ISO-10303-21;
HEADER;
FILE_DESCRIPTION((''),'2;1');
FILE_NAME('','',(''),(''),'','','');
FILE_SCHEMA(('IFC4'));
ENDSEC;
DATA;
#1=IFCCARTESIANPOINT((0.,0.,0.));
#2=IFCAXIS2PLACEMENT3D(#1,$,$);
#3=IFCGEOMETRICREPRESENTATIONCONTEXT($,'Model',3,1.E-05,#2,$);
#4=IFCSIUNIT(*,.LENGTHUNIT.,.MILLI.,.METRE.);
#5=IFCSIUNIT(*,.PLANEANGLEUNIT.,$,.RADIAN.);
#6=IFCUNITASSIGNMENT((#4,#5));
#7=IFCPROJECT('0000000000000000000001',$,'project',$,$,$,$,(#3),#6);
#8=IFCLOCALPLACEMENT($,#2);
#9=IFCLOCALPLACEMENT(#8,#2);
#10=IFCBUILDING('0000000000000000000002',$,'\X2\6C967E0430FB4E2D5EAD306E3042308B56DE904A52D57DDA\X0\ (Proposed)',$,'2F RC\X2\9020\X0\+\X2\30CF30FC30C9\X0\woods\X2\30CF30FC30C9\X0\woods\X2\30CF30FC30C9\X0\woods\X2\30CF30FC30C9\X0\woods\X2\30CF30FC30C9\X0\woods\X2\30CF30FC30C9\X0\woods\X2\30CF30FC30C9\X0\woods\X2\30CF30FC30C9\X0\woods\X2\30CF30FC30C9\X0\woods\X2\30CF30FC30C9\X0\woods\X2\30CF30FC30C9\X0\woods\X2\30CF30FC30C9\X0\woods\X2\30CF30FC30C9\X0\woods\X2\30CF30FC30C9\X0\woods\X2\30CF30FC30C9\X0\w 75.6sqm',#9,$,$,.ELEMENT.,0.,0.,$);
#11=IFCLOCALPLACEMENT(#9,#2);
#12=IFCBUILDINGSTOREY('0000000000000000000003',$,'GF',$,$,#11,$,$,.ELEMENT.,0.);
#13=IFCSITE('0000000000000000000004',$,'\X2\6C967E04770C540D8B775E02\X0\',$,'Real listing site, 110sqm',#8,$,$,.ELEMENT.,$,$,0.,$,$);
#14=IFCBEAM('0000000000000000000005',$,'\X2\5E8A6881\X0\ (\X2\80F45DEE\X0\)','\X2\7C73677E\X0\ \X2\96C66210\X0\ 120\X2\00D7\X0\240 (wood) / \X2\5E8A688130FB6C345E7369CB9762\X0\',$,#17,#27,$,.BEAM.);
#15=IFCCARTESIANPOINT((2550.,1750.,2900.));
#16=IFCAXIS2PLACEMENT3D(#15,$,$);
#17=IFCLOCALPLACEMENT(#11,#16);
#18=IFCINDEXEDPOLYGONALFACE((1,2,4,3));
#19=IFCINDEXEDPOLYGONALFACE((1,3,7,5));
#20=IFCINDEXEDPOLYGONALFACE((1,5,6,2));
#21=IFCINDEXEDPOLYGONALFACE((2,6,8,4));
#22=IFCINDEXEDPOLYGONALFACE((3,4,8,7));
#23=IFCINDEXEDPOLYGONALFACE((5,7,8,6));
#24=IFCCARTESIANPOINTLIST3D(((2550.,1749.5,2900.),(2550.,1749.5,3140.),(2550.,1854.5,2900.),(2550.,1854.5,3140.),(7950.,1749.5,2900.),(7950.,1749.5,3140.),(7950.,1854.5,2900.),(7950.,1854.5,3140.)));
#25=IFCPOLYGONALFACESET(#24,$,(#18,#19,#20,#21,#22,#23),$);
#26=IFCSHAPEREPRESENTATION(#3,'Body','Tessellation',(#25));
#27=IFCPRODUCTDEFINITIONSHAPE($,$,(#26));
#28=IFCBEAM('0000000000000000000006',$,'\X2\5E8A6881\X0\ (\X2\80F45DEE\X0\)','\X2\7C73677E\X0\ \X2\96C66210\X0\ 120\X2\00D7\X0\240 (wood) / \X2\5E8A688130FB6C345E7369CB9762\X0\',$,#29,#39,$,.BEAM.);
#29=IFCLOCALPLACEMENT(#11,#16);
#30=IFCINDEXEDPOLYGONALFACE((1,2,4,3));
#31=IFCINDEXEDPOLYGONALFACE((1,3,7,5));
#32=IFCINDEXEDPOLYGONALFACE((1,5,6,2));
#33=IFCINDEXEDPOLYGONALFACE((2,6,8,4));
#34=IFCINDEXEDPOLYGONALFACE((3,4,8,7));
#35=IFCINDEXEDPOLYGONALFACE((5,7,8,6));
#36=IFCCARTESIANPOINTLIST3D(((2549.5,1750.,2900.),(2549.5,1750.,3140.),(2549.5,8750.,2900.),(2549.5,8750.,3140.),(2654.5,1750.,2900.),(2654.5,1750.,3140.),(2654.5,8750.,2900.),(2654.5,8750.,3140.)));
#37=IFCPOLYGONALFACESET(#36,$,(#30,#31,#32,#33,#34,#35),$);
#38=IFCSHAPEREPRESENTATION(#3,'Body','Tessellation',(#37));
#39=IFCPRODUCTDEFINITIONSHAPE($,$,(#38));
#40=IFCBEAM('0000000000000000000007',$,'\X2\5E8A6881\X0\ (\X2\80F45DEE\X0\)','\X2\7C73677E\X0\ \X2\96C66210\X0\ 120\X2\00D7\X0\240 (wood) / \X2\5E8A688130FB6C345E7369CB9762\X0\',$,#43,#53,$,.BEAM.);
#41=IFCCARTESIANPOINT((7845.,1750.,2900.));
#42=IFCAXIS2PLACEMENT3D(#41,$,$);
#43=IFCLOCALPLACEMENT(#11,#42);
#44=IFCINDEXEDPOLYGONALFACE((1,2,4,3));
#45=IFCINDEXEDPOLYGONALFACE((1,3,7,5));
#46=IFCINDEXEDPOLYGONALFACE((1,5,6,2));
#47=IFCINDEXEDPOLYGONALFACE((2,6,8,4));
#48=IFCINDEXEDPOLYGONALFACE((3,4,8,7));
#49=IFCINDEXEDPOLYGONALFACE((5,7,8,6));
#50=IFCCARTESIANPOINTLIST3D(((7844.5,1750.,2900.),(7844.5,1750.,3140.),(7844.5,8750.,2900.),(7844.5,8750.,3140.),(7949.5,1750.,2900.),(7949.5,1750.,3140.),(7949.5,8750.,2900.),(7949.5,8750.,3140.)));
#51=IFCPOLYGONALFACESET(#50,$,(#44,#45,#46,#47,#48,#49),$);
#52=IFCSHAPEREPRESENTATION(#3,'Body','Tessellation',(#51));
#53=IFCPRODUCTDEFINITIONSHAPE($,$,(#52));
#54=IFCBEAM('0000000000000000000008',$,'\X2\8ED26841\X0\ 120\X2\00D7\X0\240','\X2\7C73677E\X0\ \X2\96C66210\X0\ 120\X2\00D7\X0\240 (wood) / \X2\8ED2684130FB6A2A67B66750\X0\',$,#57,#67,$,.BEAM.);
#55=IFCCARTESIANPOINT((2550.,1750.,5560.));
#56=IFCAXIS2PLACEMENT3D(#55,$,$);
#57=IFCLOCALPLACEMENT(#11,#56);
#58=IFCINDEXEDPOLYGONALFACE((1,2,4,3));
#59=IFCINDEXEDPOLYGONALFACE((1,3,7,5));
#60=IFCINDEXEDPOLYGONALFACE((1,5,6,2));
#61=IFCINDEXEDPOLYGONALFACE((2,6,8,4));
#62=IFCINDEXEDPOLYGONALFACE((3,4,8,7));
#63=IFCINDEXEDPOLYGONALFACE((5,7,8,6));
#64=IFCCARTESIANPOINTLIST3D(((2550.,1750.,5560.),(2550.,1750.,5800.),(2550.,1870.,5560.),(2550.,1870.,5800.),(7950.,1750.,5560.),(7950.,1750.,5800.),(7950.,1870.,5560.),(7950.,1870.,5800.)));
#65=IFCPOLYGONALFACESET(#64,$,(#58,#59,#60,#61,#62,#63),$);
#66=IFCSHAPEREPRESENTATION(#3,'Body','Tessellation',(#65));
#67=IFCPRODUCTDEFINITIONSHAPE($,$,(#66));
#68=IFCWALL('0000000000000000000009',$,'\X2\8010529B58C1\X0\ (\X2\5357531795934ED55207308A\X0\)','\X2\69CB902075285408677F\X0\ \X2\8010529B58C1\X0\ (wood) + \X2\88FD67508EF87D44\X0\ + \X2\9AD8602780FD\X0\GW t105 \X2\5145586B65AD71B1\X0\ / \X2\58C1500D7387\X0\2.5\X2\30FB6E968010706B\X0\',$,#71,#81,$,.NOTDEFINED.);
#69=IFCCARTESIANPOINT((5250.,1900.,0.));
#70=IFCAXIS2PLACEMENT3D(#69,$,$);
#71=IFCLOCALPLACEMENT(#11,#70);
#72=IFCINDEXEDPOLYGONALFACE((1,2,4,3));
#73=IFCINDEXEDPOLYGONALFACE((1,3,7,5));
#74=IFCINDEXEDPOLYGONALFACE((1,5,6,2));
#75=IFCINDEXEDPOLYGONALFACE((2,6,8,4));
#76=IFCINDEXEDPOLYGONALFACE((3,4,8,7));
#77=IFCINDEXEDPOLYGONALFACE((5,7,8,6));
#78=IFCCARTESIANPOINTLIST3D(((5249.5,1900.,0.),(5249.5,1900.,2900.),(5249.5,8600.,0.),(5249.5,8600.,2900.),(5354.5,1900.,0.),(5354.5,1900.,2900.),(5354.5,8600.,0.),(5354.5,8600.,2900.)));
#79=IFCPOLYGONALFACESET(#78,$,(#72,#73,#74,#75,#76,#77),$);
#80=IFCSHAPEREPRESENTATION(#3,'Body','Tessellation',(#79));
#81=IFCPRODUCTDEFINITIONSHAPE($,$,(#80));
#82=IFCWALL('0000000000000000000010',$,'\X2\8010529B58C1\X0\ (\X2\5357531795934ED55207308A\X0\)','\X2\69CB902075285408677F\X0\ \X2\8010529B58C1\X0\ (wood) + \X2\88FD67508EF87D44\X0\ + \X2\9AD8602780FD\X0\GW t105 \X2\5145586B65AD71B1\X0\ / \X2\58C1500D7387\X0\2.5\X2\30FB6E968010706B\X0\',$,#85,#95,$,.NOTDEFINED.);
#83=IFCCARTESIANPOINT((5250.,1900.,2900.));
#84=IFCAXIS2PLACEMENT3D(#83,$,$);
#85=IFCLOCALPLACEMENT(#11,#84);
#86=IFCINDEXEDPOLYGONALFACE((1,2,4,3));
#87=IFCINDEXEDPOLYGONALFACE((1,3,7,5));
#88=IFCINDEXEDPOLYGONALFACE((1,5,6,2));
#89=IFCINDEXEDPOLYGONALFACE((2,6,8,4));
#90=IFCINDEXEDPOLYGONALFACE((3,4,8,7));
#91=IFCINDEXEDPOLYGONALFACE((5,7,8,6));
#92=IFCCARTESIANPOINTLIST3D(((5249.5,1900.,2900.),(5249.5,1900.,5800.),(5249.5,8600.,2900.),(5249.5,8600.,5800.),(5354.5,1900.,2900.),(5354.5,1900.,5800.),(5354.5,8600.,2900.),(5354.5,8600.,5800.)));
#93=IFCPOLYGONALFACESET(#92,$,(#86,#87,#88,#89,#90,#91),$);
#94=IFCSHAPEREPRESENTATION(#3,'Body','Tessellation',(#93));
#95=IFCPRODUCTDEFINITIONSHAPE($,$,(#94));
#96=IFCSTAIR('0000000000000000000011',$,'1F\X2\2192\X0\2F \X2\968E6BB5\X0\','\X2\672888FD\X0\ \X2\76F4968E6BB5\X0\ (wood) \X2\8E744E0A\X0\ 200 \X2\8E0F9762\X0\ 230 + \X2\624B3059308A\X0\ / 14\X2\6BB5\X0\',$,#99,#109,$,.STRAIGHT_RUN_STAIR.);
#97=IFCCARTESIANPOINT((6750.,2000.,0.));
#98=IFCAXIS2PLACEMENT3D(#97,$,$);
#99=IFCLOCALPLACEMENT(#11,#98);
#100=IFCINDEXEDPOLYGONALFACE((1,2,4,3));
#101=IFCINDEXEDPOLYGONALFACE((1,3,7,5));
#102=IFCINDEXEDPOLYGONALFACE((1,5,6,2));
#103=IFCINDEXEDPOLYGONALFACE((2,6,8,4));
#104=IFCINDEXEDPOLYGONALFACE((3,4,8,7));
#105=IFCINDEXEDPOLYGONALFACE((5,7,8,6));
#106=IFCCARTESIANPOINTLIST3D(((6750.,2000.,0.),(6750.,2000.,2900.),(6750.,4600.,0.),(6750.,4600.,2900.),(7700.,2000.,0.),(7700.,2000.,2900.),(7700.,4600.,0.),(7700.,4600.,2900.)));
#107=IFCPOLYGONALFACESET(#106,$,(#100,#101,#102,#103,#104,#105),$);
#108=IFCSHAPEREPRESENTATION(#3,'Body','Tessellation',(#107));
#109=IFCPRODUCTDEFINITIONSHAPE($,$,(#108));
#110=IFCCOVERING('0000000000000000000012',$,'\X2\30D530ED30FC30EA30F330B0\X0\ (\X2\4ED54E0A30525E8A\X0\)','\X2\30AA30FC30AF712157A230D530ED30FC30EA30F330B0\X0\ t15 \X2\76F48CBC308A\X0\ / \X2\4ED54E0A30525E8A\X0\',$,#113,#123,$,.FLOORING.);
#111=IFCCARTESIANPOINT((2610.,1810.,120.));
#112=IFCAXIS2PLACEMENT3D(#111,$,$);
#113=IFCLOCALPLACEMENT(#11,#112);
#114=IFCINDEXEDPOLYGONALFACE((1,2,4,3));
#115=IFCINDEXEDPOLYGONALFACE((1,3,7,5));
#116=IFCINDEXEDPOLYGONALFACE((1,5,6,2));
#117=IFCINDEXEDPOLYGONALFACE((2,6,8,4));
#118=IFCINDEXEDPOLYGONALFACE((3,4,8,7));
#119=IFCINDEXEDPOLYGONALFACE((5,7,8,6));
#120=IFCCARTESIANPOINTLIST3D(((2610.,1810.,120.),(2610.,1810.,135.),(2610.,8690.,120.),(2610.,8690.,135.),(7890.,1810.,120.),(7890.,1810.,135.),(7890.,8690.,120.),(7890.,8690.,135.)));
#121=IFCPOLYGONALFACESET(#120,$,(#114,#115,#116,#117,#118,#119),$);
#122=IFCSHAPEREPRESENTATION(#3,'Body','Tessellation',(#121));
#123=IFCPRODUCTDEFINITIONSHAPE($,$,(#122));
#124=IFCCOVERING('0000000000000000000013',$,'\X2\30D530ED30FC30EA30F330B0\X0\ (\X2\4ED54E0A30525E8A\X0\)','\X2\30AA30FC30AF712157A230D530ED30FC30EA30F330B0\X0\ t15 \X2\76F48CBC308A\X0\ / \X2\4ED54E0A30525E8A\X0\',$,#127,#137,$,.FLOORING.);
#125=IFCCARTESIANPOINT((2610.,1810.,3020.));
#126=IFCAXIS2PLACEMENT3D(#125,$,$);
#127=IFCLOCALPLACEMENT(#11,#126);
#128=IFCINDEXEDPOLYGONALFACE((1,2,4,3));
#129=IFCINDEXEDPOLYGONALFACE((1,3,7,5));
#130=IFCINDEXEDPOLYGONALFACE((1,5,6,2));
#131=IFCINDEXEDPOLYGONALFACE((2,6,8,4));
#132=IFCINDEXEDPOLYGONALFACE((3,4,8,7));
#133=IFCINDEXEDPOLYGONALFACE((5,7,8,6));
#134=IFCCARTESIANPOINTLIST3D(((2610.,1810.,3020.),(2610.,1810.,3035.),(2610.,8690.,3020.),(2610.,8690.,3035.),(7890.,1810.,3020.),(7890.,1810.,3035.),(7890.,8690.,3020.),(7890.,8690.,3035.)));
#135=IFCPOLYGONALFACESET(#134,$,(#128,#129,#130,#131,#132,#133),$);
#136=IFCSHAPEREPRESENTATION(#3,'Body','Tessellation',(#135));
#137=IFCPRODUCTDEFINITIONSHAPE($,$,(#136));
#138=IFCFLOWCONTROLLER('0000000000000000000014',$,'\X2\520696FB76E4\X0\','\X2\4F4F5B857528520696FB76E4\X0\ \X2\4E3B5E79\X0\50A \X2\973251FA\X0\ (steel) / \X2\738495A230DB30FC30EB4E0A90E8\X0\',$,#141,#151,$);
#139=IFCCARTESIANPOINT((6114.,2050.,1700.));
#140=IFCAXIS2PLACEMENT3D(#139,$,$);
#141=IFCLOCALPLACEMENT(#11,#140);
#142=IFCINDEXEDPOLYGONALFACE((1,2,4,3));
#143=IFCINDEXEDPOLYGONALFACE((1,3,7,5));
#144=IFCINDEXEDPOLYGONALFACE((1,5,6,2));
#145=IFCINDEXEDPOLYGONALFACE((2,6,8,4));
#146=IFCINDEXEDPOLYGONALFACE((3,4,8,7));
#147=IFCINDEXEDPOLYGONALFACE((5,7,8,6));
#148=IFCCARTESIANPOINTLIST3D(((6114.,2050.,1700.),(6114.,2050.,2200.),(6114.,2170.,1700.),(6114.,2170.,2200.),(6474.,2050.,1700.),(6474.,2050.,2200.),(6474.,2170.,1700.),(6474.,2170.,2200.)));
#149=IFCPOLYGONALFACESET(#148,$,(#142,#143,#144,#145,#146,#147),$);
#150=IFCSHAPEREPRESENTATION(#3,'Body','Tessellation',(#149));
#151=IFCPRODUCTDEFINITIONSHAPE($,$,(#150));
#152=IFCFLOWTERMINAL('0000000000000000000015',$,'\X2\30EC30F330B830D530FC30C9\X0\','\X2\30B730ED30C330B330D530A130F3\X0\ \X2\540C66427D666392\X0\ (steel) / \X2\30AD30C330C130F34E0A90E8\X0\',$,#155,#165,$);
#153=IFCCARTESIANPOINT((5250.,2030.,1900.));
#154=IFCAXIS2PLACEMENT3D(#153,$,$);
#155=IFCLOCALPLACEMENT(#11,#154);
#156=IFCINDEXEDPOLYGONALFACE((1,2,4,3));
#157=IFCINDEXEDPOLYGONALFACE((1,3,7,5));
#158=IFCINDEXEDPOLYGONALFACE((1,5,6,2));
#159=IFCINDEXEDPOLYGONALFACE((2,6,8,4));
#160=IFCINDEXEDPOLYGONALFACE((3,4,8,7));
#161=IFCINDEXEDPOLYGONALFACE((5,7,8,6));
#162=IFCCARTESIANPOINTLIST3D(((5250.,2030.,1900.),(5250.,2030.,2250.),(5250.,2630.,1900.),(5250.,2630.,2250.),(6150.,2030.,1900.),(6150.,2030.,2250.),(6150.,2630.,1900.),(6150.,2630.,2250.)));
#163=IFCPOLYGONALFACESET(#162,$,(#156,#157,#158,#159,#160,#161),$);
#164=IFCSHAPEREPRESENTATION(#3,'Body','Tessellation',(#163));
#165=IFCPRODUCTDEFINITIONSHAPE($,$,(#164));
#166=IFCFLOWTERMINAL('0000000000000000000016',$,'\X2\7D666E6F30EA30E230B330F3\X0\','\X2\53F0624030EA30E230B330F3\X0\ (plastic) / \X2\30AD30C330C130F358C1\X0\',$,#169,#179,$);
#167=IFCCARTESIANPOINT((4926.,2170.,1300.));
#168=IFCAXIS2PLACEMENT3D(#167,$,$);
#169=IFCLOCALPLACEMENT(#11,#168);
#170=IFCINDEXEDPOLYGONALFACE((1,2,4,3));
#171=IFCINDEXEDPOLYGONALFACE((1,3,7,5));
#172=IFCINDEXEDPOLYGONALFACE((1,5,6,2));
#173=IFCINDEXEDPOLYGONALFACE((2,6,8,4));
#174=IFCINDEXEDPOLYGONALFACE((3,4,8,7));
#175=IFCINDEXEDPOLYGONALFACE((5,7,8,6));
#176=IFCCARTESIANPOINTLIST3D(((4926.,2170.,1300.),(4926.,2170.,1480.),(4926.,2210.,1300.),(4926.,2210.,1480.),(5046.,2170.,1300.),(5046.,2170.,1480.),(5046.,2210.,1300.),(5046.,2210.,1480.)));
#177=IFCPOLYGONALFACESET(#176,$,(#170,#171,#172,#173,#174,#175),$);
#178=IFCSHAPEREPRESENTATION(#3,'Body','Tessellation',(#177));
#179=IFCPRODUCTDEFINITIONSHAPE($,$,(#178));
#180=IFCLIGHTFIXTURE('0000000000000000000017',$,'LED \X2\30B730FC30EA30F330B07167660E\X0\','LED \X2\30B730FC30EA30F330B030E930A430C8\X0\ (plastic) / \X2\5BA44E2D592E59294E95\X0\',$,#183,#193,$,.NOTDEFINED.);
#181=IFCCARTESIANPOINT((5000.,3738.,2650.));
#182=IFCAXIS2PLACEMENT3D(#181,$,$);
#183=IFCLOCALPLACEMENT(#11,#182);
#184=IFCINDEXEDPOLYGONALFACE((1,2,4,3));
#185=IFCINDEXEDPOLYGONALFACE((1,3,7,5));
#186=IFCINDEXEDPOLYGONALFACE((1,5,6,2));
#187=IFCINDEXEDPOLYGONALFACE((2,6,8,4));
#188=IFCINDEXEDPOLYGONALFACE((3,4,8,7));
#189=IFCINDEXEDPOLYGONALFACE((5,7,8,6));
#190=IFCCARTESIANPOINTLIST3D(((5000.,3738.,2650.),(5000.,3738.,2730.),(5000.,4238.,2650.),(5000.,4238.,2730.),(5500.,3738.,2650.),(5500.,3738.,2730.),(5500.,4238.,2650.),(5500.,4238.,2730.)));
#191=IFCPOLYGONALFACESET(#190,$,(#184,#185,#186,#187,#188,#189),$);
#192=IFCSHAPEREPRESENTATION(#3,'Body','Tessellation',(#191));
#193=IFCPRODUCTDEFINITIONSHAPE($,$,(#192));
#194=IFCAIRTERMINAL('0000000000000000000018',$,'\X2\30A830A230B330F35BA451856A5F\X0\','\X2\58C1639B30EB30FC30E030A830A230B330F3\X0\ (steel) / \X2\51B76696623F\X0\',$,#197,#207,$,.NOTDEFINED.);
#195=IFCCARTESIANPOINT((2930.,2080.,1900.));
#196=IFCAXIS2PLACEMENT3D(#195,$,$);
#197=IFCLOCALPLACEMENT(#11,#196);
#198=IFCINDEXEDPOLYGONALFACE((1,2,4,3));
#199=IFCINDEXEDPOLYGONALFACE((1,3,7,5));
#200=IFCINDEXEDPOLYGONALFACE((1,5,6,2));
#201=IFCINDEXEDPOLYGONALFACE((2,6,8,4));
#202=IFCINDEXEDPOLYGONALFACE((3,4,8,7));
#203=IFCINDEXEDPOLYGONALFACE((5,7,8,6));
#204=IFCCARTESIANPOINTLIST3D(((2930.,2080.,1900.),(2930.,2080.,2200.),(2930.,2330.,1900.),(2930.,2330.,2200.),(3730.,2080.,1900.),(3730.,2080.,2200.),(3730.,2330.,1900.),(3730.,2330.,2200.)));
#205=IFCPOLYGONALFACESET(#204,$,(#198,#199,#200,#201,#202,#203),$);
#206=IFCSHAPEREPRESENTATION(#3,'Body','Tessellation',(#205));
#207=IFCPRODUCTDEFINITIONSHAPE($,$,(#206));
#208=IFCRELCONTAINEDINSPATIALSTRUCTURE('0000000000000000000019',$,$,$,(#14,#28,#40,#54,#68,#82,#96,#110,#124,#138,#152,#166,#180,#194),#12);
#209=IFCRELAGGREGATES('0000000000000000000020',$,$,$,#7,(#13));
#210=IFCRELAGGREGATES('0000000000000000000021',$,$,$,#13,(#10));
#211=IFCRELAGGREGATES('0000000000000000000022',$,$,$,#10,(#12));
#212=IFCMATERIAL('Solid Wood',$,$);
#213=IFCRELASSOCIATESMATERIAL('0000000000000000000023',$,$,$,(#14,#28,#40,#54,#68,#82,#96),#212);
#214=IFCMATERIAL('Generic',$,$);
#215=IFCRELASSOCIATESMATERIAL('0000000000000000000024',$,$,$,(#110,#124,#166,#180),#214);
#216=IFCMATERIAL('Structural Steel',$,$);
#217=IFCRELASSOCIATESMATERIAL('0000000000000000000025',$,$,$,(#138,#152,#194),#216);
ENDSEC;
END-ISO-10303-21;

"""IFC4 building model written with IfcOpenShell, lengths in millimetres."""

from ifc_helpers import new_model, si_unit, frame, frame_2d, origin, place, context, project, spatial, rectangle, extrude, material, element, save


model = new_model("IFC4")

# Units and contexts
model_context = context("Model", 3, precision=1e-05, world=origin())
ifc_project = project(units=[si_unit("LENGTHUNIT", "METRE", prefix="MILLI"), si_unit("PLANEANGLEUNIT", "RADIAN")], contexts=[model_context])

# Site, building, storey
site_placement = place(None, origin())
site = spatial("IfcSite", under=ifc_project, at=site_placement, Name="沖縄県名護市", ObjectType="Real listing site, 110sqm", CompositionType="ELEMENT", RefElevation=0.0)
building_placement = place(site_placement, origin())
building = spatial("IfcBuilding", under=site, at=building_placement, Name="沖縄・中庭のある回遊動線 (Proposed)", ObjectType="2F RC造+ハードwoodsハードwoodsハードwoodsハードwoodsハードwoodsハードwoodsハードwoodsハードwoodsハードwoodsハードwoodsハードwoodsハードwoodsハードwoodsハードwoodsハードw 75.6sqm", CompositionType="ELEMENT", ElevationOfRefHeight=0.0, ElevationOfTerrain=0.0)
storey_placement = place(building_placement, origin())
storey = spatial("IfcBuildingStorey", under=building, at=storey_placement, Name="GF", CompositionType="ELEMENT", Elevation=0.0)

# Shared definitions
ifc_material_1 = material(Name="Solid Wood")

# Beams
beam_1_placement = place(storey_placement, frame((2550.0, 1750.0, 2900.0)))
element("IfcBeam", 1, at=beam_1_placement, inside=storey, material=ifc_material_1, Name="床梁 (胴差)", Description="米松 集成 120×240 (wood) / 床梁・水平構面", PredefinedType="BEAM", context=model_context, shape_type="SweptSolid", body=[
    extrude(rectangle(XDim=5400.0, YDim=105.0, at=frame_2d((2700.0, 52.0))), frame((2550.0, 1750.0, 2900.0)), (0.0, 0.0, 1.0), 240.0),
])
beam_2_placement = place(storey_placement, frame((2550.0, 1750.0, 2900.0)))
element("IfcBeam", 2, at=beam_2_placement, inside=storey, material=ifc_material_1, Name="床梁 (胴差)", Description="米松 集成 120×240 (wood) / 床梁・水平構面", PredefinedType="BEAM", context=model_context, shape_type="SweptSolid", body=[
    extrude(rectangle(XDim=105.0, YDim=7000.0, at=frame_2d((52.0, 3500.0))), frame((2550.0, 1750.0, 2900.0)), (0.0, 0.0, 1.0), 240.0),
])
beam_3_placement = place(storey_placement, frame((7845.0, 1750.0, 2900.0)))
element("IfcBeam", 3, at=beam_3_placement, inside=storey, material=ifc_material_1, Name="床梁 (胴差)", Description="米松 集成 120×240 (wood) / 床梁・水平構面", PredefinedType="BEAM", context=model_context, shape_type="SweptSolid", body=[
    extrude(rectangle(XDim=105.0, YDim=7000.0, at=frame_2d((52.0, 3500.0))), frame((7845.0, 1750.0, 2900.0)), (0.0, 0.0, 1.0), 240.0),
])
beam_4_placement = place(storey_placement, frame((2550.0, 1750.0, 5560.0)))
element("IfcBeam", 4, at=beam_4_placement, inside=storey, material=ifc_material_1, Name="軒桁 120×240", Description="米松 集成 120×240 (wood) / 軒桁・横架材", PredefinedType="BEAM", context=model_context, shape_type="SweptSolid", body=[
    extrude(rectangle(XDim=5400.0, YDim=120.0, at=frame_2d((2700.0, 60.0))), frame((2550.0, 1750.0, 5560.0)), (0.0, 0.0, 1.0), 240.0),
])

# Walls
wall_1_placement = place(storey_placement, frame((5250.0, 1900.0, 0.0)))
element("IfcWall", 5, at=wall_1_placement, inside=storey, material=ifc_material_1, Name="耐力壁 (南北間仕切り)", Description="構造用合板 耐力壁 (wood) + 製材軸組 + 高性能GW t105 充填断熱 / 壁倍率2.5・準耐火", PredefinedType="NOTDEFINED", context=model_context, shape_type="SweptSolid", body=[
    extrude(rectangle(XDim=105.0, YDim=6700.0, at=frame_2d((52.0, 3350.0))), frame((5250.0, 1900.0, 0.0)), (0.0, 0.0, 1.0), 2900.0),
])
wall_2_placement = place(storey_placement, frame((5250.0, 1900.0, 2900.0)))
element("IfcWall", 6, at=wall_2_placement, inside=storey, material=ifc_material_1, Name="耐力壁 (南北間仕切り)", Description="構造用合板 耐力壁 (wood) + 製材軸組 + 高性能GW t105 充填断熱 / 壁倍率2.5・準耐火", PredefinedType="NOTDEFINED", context=model_context, shape_type="SweptSolid", body=[
    extrude(rectangle(XDim=105.0, YDim=6700.0, at=frame_2d((52.0, 3350.0))), frame((5250.0, 1900.0, 2900.0)), (0.0, 0.0, 1.0), 2900.0),
])

# Stair
stair_placement = place(storey_placement, frame((6750.0, 2000.0, 0.0)))
element("IfcStair", 7, at=stair_placement, inside=storey, material=ifc_material_1, Name="1F→2F 階段", Description="木製 直階段 (wood) 蹴上 200 踏面 230 + 手すり / 14段", PredefinedType="STRAIGHT_RUN_STAIR", context=model_context, shape_type="SweptSolid", body=[
    extrude(rectangle(XDim=950.0, YDim=2600.0, at=frame_2d((475.0, 1300.0))), frame((6750.0, 2000.0, 0.0)), (0.0, 0.0, 1.0), 2900.0),
])

# Coverings
ifc_material_2 = material(Name="Generic")
covering_1_placement = place(storey_placement, frame((2610.0, 1810.0, 120.0)))
element("IfcCovering", 8, at=covering_1_placement, inside=storey, material=ifc_material_2, Name="フローリング (仕上げ床)", Description="オーク無垢フローリング t15 直貼り / 仕上げ床", PredefinedType="FLOORING", context=model_context, shape_type="SweptSolid", body=[
    extrude(rectangle(XDim=5280.0, YDim=6880.0, at=frame_2d((2640.0, 3440.0))), frame((2610.0, 1810.0, 120.0)), (0.0, 0.0, 1.0), 15.0),
])
covering_2_placement = place(storey_placement, frame((2610.0, 1810.0, 3020.0)))
element("IfcCovering", 9, at=covering_2_placement, inside=storey, material=ifc_material_2, Name="フローリング (仕上げ床)", Description="オーク無垢フローリング t15 直貼り / 仕上げ床", PredefinedType="FLOORING", context=model_context, shape_type="SweptSolid", body=[
    extrude(rectangle(XDim=5280.0, YDim=6880.0, at=frame_2d((2640.0, 3440.0))), frame((2610.0, 1810.0, 3020.0)), (0.0, 0.0, 1.0), 15.0),
])

# Flow controller
ifc_material_3 = material(Name="Structural Steel")
flow_controller_placement = place(storey_placement, frame((6114.0, 2050.0, 1700.0)))
element("IfcFlowController", 10, at=flow_controller_placement, inside=storey, material=ifc_material_3, Name="分電盤", Description="住宅用分電盤 主幹50A 露出 (steel) / 玄関ホール上部", context=model_context, shape_type="SweptSolid", body=[
    extrude(rectangle(XDim=360.0, YDim=120.0, at=frame_2d((180.0, 60.0))), frame((6114.0, 2050.0, 1700.0)), (0.0, 0.0, 1.0), 500.0),
])

# Flow terminals
flow_terminal_1_placement = place(storey_placement, frame((5250.0, 2030.0, 1900.0)))
element("IfcFlowTerminal", 11, at=flow_terminal_1_placement, inside=storey, material=ifc_material_3, Name="レンジフード", Description="シロッコファン 同時給排 (steel) / キッチン上部", context=model_context, shape_type="SweptSolid", body=[
    extrude(rectangle(XDim=900.0, YDim=600.0, at=frame_2d((450.0, 300.0))), frame((5250.0, 2030.0, 1900.0)), (0.0, 0.0, 1.0), 350.0),
])
flow_terminal_2_placement = place(storey_placement, frame((4926.0, 2170.0, 1300.0)))
element("IfcFlowTerminal", 12, at=flow_terminal_2_placement, inside=storey, material=ifc_material_2, Name="給湯リモコン", Description="台所リモコン (plastic) / キッチン壁", context=model_context, shape_type="SweptSolid", body=[
    extrude(rectangle(XDim=120.0, YDim=40.0, at=frame_2d((60.0, 20.0))), frame((4926.0, 2170.0, 1300.0)), (0.0, 0.0, 1.0), 180.0),
])

# Light fixture
light_fixture_1_placement = place(storey_placement, frame((5000.0, 3738.0, 2650.0)))
element("IfcLightFixture", 13, at=light_fixture_1_placement, inside=storey, material=ifc_material_2, Name="LED シーリング照明", Description="LED シーリングライト (plastic) / 室中央天井", PredefinedType="NOTDEFINED", context=model_context, shape_type="SweptSolid", body=[
    extrude(rectangle(XDim=500.0, YDim=500.0, at=frame_2d((250.0, 250.0))), frame((5000.0, 3738.0, 2650.0)), (0.0, 0.0, 1.0), 80.0),
])

# Air terminal
air_terminal_1_placement = place(storey_placement, frame((2930.0, 2080.0, 1900.0)))
element("IfcAirTerminal", 14, at=air_terminal_1_placement, inside=storey, material=ifc_material_3, Name="エアコン室内機", Description="壁掛ルームエアコン (steel) / 冷暖房", PredefinedType="NOTDEFINED", context=model_context, shape_type="SweptSolid", body=[
    extrude(rectangle(XDim=800.0, YDim=250.0, at=frame_2d((400.0, 125.0))), frame((2930.0, 2080.0, 1900.0)), (0.0, 0.0, 1.0), 300.0),
])

save(model, "model.ifc")
